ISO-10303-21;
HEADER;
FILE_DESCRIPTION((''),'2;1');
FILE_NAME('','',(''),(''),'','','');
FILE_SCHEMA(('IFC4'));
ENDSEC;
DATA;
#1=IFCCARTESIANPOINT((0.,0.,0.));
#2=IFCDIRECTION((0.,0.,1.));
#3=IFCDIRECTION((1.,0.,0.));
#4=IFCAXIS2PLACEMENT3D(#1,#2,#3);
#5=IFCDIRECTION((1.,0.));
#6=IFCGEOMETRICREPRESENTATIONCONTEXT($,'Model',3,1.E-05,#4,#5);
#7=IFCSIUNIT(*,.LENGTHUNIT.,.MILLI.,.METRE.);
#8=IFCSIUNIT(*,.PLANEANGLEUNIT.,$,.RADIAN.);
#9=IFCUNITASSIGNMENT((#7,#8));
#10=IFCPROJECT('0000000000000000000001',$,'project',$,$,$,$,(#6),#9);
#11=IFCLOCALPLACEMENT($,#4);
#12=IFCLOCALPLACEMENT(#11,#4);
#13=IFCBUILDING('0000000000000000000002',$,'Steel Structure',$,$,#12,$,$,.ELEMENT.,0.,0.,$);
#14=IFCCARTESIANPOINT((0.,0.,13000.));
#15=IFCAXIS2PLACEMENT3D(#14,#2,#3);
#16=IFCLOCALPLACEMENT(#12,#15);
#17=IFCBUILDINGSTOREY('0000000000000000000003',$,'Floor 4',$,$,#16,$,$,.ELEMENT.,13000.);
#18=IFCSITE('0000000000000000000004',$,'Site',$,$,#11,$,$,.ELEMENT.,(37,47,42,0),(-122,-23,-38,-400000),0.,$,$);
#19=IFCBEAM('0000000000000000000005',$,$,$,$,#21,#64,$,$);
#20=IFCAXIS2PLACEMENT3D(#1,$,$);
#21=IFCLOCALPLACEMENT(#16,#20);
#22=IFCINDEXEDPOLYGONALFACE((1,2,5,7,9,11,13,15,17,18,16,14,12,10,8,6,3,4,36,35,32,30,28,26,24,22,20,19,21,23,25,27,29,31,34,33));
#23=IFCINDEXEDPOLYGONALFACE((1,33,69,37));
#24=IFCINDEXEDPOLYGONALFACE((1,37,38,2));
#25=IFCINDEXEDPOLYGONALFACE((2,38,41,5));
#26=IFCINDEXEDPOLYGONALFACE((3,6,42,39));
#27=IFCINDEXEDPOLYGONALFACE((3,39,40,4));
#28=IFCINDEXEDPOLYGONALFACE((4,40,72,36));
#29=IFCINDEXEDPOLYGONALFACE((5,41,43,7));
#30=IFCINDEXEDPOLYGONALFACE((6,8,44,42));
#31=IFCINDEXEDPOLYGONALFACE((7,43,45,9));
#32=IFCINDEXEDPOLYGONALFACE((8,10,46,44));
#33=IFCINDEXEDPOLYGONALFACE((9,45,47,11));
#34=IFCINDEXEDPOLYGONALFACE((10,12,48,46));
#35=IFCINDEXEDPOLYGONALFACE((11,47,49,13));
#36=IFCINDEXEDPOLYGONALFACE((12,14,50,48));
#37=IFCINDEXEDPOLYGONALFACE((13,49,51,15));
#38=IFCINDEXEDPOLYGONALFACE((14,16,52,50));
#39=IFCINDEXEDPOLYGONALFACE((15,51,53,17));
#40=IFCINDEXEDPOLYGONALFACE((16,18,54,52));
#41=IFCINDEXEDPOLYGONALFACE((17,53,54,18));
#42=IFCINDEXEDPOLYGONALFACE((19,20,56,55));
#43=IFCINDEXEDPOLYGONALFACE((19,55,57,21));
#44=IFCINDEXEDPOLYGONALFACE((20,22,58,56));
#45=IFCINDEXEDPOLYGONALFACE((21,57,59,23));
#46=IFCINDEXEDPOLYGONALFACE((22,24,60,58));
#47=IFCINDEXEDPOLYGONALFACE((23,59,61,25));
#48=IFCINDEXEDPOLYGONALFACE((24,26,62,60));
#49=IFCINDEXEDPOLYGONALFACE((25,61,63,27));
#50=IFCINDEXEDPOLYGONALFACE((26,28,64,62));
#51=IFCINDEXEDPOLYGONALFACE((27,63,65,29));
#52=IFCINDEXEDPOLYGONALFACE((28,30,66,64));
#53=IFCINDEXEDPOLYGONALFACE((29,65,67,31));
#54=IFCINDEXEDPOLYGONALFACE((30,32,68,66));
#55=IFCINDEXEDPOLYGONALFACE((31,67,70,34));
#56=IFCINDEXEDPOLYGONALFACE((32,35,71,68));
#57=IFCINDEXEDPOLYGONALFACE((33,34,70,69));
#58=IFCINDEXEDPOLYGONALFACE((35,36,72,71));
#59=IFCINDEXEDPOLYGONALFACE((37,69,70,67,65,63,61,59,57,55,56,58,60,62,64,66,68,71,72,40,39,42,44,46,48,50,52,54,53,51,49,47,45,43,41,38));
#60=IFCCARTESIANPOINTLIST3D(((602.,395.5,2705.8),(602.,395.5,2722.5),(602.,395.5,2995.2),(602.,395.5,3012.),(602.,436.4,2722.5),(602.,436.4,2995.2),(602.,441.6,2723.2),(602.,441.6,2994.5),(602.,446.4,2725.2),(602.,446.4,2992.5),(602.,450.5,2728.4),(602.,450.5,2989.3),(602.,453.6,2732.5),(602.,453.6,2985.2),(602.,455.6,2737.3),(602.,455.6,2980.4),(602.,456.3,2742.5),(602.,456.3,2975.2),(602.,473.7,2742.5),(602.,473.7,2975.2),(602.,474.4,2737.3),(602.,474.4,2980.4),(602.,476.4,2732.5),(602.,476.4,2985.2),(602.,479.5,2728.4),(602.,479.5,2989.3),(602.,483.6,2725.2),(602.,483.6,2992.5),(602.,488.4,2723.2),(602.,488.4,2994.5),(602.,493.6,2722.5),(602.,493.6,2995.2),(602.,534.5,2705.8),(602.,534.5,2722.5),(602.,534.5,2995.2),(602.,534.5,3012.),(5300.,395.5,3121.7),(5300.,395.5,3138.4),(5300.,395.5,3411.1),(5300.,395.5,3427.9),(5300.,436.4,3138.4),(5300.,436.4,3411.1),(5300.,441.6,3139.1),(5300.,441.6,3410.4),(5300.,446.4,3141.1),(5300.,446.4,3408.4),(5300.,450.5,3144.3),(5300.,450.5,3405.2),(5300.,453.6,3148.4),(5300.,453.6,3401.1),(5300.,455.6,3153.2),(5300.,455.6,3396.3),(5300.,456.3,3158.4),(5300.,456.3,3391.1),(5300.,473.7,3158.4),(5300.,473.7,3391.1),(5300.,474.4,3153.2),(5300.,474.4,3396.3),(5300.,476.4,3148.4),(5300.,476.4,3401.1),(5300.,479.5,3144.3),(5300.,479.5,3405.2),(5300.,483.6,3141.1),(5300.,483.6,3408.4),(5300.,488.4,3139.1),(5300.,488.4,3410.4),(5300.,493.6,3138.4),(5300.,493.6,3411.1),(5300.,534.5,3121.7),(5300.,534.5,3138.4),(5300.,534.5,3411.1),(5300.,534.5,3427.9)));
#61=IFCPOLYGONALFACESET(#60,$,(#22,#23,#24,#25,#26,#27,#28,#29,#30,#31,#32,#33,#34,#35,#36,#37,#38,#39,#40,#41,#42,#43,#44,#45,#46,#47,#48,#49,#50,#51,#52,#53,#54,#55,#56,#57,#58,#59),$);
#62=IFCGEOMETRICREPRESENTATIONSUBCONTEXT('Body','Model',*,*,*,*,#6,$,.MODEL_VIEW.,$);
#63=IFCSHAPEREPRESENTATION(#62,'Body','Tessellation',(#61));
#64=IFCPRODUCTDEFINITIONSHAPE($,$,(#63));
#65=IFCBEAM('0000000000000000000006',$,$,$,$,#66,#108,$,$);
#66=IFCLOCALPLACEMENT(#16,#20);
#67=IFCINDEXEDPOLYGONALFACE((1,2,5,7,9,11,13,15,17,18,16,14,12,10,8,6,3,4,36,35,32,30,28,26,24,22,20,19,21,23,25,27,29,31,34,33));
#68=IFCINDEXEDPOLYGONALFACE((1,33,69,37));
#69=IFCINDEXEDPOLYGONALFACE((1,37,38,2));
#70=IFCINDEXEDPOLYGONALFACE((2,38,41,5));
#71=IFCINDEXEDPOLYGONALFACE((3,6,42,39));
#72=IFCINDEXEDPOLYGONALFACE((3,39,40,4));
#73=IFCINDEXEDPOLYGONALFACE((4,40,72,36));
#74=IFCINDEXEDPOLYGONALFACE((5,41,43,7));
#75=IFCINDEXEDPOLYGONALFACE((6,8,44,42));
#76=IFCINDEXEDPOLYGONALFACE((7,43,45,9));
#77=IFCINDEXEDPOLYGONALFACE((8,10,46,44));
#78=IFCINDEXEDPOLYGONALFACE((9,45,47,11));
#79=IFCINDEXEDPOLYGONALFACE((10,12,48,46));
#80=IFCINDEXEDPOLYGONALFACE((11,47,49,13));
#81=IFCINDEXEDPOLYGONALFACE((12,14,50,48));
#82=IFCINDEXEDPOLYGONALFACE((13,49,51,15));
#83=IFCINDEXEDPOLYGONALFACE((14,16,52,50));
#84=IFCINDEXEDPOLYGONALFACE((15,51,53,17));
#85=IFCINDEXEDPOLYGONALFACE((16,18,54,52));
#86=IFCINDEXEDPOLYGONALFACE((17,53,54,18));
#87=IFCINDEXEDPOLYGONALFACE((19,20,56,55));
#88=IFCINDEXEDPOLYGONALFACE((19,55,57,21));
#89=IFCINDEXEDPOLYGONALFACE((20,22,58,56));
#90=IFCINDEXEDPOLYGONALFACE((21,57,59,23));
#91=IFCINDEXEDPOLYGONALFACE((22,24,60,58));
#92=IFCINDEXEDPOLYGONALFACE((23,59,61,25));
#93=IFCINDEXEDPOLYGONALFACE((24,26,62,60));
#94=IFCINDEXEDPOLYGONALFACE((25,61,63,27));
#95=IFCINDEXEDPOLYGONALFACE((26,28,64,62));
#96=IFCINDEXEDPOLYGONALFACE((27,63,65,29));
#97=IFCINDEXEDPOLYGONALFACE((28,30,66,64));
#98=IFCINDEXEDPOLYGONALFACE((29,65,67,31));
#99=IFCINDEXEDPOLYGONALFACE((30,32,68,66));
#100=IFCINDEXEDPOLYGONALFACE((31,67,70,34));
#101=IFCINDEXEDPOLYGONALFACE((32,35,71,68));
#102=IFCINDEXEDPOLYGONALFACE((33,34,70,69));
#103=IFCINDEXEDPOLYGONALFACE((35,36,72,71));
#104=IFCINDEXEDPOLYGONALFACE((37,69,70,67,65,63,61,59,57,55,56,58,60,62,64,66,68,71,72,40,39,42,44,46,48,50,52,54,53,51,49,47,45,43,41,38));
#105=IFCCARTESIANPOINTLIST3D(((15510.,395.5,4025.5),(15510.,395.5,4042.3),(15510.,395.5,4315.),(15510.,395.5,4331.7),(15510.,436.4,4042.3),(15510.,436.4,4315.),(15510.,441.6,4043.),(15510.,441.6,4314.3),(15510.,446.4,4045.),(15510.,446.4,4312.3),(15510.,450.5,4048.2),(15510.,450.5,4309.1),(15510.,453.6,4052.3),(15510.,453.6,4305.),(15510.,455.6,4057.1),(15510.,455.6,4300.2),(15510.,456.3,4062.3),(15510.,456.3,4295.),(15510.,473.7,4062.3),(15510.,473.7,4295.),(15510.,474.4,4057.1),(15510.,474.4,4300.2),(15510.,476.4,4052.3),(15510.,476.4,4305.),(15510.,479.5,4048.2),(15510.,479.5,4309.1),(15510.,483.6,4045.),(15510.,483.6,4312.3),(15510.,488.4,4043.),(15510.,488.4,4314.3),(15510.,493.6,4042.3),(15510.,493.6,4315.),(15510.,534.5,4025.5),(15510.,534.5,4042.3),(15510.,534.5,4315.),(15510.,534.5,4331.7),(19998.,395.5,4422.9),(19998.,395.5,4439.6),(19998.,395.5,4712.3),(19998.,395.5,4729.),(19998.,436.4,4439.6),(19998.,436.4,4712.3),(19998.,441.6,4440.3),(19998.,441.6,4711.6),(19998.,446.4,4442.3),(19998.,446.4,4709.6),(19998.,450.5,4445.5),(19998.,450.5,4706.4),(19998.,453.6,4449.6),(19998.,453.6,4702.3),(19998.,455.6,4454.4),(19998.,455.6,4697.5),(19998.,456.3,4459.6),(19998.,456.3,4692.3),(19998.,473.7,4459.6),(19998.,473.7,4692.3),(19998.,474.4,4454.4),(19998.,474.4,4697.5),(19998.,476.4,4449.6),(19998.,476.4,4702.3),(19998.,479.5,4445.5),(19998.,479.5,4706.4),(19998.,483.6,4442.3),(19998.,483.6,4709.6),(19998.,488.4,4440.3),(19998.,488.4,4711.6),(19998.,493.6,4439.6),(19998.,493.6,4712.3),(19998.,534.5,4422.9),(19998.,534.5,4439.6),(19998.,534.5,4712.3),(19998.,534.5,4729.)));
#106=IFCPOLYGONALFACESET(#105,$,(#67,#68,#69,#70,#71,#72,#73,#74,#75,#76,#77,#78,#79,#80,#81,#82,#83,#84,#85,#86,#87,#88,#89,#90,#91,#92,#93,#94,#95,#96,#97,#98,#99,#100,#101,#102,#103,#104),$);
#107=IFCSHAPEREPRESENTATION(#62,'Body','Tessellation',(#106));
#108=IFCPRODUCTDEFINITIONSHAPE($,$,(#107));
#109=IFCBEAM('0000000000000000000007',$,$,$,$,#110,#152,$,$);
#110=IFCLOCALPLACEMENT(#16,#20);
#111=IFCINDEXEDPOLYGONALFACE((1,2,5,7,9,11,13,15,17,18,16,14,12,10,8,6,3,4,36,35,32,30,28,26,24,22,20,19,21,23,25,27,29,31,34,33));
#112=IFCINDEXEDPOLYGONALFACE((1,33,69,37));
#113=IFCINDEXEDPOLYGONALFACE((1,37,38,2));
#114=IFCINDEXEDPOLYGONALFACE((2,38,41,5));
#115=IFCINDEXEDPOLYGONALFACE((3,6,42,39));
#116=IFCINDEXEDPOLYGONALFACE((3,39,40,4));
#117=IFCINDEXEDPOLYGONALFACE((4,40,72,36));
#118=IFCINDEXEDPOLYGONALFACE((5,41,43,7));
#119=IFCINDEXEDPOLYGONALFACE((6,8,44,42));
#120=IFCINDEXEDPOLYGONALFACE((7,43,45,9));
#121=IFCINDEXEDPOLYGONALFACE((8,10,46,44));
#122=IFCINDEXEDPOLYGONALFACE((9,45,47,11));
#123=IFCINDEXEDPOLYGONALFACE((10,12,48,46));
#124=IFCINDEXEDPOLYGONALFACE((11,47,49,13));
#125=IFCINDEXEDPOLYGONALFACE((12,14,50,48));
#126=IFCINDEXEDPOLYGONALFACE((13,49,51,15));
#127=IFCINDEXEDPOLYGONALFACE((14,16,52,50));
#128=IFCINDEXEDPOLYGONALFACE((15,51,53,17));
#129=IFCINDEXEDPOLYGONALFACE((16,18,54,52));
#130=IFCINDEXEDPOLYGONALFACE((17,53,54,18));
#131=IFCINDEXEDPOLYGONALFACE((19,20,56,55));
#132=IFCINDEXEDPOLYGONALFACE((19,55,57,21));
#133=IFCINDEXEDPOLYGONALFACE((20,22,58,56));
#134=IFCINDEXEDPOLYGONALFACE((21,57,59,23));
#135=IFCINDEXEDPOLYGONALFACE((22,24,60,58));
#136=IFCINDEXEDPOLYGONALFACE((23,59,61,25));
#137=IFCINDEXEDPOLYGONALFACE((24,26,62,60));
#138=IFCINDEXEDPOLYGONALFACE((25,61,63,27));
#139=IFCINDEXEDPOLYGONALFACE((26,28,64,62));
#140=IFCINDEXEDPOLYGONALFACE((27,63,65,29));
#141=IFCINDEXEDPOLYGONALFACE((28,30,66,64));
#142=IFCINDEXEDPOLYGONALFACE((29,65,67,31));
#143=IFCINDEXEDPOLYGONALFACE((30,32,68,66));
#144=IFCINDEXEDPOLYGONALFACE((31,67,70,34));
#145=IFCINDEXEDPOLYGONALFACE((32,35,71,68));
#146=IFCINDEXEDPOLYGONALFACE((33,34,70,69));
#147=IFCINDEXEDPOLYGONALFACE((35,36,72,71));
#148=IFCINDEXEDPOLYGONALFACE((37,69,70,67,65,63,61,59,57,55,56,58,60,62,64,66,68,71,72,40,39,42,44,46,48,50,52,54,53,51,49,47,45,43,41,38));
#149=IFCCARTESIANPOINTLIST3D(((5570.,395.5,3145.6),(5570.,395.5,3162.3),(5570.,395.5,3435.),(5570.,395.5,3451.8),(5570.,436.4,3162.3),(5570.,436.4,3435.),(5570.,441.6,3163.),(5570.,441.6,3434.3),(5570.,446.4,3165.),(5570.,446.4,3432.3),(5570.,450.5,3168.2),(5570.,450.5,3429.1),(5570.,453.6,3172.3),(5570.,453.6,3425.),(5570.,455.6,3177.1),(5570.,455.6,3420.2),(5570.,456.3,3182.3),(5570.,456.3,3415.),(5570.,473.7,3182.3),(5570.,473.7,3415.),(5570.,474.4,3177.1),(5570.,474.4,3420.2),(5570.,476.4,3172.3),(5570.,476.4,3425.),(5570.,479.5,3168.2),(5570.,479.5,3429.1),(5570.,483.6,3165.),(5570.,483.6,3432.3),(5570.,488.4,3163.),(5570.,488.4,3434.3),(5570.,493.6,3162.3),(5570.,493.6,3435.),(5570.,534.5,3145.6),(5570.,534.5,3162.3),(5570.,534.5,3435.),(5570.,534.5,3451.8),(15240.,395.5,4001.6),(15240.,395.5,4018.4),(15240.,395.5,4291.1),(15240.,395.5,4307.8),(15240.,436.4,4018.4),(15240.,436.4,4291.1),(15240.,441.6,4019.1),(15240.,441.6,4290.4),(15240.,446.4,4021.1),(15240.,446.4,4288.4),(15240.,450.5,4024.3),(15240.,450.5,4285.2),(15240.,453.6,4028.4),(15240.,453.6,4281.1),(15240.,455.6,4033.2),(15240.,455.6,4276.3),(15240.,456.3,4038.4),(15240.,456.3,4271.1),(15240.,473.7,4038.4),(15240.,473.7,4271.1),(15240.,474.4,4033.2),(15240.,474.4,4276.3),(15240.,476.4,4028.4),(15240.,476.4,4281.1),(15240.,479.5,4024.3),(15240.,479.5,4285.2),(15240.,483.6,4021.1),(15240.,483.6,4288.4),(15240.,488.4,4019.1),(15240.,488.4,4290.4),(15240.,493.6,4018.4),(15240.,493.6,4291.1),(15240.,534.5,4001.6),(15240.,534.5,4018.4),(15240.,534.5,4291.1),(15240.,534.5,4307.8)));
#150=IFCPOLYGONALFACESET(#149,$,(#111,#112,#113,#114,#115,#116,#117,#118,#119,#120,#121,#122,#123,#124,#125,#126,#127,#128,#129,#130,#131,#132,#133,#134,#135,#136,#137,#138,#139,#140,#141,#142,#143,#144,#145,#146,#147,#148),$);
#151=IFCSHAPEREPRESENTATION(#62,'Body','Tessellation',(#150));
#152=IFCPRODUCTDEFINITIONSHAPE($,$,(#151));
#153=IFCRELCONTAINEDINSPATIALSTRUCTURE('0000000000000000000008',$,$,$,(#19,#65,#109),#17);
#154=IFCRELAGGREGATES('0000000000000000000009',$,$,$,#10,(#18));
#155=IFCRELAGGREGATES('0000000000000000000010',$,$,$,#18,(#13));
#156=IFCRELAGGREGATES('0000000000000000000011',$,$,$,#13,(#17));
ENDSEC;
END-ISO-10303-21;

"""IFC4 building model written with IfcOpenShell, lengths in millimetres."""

from ifc_helpers import new_model, si_unit, direction, frame, origin_with_axes, origin_2d_with_axis, place, context, subcontext, project, spatial, polyline, i_section, extrude, clip, bounded_halfspace, element, save


model = new_model("IFC4")

# Units and contexts
model_context = context("Model", 3, precision=1e-05, world=origin_with_axes(), true_north=direction((1.0, 0.0)))
body_context = subcontext(model_context, "Body", "Model", "MODEL_VIEW")
ifc_project = project(units=[si_unit("LENGTHUNIT", "METRE", prefix="MILLI"), si_unit("PLANEANGLEUNIT", "RADIAN")], contexts=[model_context])

# Site, building, storey
site_placement = place(None, origin_with_axes())
site = spatial("IfcSite", under=ifc_project, at=site_placement, Name="Site", CompositionType="ELEMENT", RefLatitude=(37, 47, 42, 0), RefLongitude=(-122, -23, -38, -400000), RefElevation=0.0)
building_placement = place(site_placement, origin_with_axes())
building = spatial("IfcBuilding", under=site, at=building_placement, Name="Steel Structure", CompositionType="ELEMENT", ElevationOfRefHeight=0.0, ElevationOfTerrain=0.0)
storey_placement = place(building_placement, frame((0.0, 0.0, 13000.0), z_axis=(0.0, 0.0, 1.0), x_axis=(1.0, 0.0, 0.0)))
storey = spatial("IfcBuildingStorey", under=building, at=storey_placement, Name="Floor 4", CompositionType="ELEMENT", Elevation=13000.0)

# Beams
beam_1_placement = place(storey_placement, frame((602.0, 465.0, 2705.8), z_axis=(0.996104, 0.0, 0.088184), x_axis=(0.0, 1.0, 0.0)))
element("IfcBeam", 1, at=beam_1_placement, inside=storey, context=body_context, shape_type="Clipping", body=[
    clip(clip(extrude(i_section(OverallWidth=139.0, OverallDepth=305.0, WebThickness=17.4, FlangeThickness=16.7, FilletRadius=19.9, at=origin_2d_with_axis()), frame((0.0, 152.5, 0.0), z_axis=(0.0, 0.0, 1.0), x_axis=(1.0, 0.0, 0.0)), (0.0, 0.0, 1.0), 4743.4), bounded_halfspace(frame((-465.0, -15644.6, -1385.0), z_axis=(0.0, 0.088184, -0.996104), x_axis=(-1.0, 0.0, 0.0)), False, frame((0.0, 152.5, 0.0), z_axis=(0.0, 0.0, 1.0), x_axis=(1.0, 0.0, 0.0)), polyline([(69.5, 152.5), (69.5, 135.8), (28.6, 135.8), (8.7, 115.9), (8.7, -115.9), (28.6, -135.8), (69.5, -135.8), (69.5, -152.5), (-69.5, -152.5), (-69.5, -135.8), (-28.6, -135.8), (-8.7, -115.9), (-8.7, 115.9), (-28.6, 135.8), (-69.5, 135.8), (-69.5, 152.5), (69.5, 152.5)]))), bounded_halfspace(frame((-465.0, -16058.9, 3294.7), z_axis=(0.0, -0.088184, 0.996104), x_axis=(1.0, 0.0, 0.0)), False, frame((0.0, 152.5, 0.0), z_axis=(0.0, 0.0, 1.0), x_axis=(1.0, 0.0, 0.0)), polyline([(-69.5, -135.8), (-69.5, -152.5), (69.5, -152.5), (69.5, -135.8), (28.6, -135.8), (8.7, -115.9), (8.7, 115.9), (28.6, 135.8), (69.5, 135.8), (69.5, 152.5), (-69.5, 152.5), (-69.5, 135.8), (-28.6, 135.8), (-8.7, 115.9), (-8.7, -115.9), (-28.6, -135.8), (-69.5, -135.8)]))),
])
beam_2_placement = place(storey_placement, frame((15510.0, 465.0, 4025.5), z_axis=(0.996104, 0.0, 0.088184), x_axis=(0.0, 1.0, 0.0)))
element("IfcBeam", 2, at=beam_2_placement, inside=storey, context=body_context, shape_type="Clipping", body=[
    clip(clip(extrude(i_section(OverallWidth=139.0, OverallDepth=305.0, WebThickness=17.4, FlangeThickness=16.7, FilletRadius=19.9, at=origin_2d_with_axis()), frame((0.0, 152.5, 0.0), z_axis=(0.0, 0.0, 1.0), x_axis=(1.0, 0.0, 0.0)), (0.0, 0.0, 1.0), 4532.6), bounded_halfspace(frame((-465.0, -16959.2, -1501.4), z_axis=(0.0, 0.088184, -0.996104), x_axis=(-1.0, 0.0, 0.0)), False, frame((0.0, 152.5, 0.0), z_axis=(0.0, 0.0, 1.0), x_axis=(1.0, 0.0, 0.0)), polyline([(-69.5, -152.5), (-69.5, -135.8), (-28.6, -135.8), (-8.7, -115.9), (-8.7, 115.9), (-28.6, 135.8), (-69.5, 135.8), (-69.5, 152.5), (69.5, 152.5), (69.5, 135.8), (28.6, 135.8), (8.7, 115.9), (8.7, -115.9), (28.6, -135.8), (69.5, -135.8), (69.5, -152.5), (-69.5, -152.5)]))), bounded_halfspace(frame((-465.0, -17355.0, 2969.2), z_axis=(0.0, -0.088184, 0.996104), x_axis=(1.0, 0.0, 0.0)), False, frame((0.0, 152.5, 0.0), z_axis=(0.0, 0.0, 1.0), x_axis=(1.0, 0.0, 0.0)), polyline([(69.5, 135.8), (69.5, 152.5), (-69.5, 152.5), (-69.5, 135.8), (-28.6, 135.8), (-8.7, 115.9), (-8.7, -115.9), (-28.6, -135.8), (-69.5, -135.8), (-69.5, -152.5), (69.5, -152.5), (69.5, -135.8), (28.6, -135.8), (8.7, -115.9), (8.7, 115.9), (28.6, 135.8), (69.5, 135.8)]))),
])
beam_3_placement = place(storey_placement, frame((5570.0, 465.0, 3145.6), z_axis=(0.996104, 0.0, 0.088184), x_axis=(0.0, 1.0, 0.0)))
element("IfcBeam", 3, at=beam_3_placement, inside=storey, context=body_context, shape_type="Clipping", body=[
    clip(clip(extrude(i_section(OverallWidth=139.0, OverallDepth=305.0, WebThickness=17.4, FlangeThickness=16.7, FilletRadius=19.9, at=origin_2d_with_axis()), frame((0.0, 152.5, 0.0), z_axis=(0.0, 0.0, 1.0), x_axis=(1.0, 0.0, 0.0)), (0.0, 0.0, 1.0), 9734.8), bounded_halfspace(frame((-465.0, -16082.7, -1423.8), z_axis=(0.0, 0.088184, -0.996104), x_axis=(-1.0, 0.0, 0.0)), False, frame((0.0, 152.5, 0.0), z_axis=(0.0, 0.0, 1.0), x_axis=(1.0, 0.0, 0.0)), polyline([(69.5, 152.5), (69.5, 135.8), (28.6, 135.8), (8.7, 115.9), (8.7, -115.9), (28.6, -135.8), (69.5, -135.8), (69.5, -152.5), (-69.5, -152.5), (-69.5, -135.8), (-28.6, -135.8), (-8.7, -115.9), (-8.7, 115.9), (-28.6, 135.8), (-69.5, 135.8), (-69.5, 152.5), (69.5, 152.5)]))), bounded_halfspace(frame((-465.0, -16935.4, 8208.5), z_axis=(0.0, -0.088184, 0.996104), x_axis=(1.0, 0.0, 0.0)), False, frame((0.0, 152.5, 0.0), z_axis=(0.0, 0.0, 1.0), x_axis=(1.0, 0.0, 0.0)), polyline([(69.5, 135.8), (69.5, 152.5), (-69.5, 152.5), (-69.5, 135.8), (-28.6, 135.8), (-8.7, 115.9), (-8.7, -115.9), (-28.6, -135.8), (-69.5, -135.8), (-69.5, -152.5), (69.5, -152.5), (69.5, -135.8), (28.6, -135.8), (8.7, -115.9), (8.7, 115.9), (28.6, 135.8), (69.5, 135.8)]))),
])

save(model, "model.ifc")
